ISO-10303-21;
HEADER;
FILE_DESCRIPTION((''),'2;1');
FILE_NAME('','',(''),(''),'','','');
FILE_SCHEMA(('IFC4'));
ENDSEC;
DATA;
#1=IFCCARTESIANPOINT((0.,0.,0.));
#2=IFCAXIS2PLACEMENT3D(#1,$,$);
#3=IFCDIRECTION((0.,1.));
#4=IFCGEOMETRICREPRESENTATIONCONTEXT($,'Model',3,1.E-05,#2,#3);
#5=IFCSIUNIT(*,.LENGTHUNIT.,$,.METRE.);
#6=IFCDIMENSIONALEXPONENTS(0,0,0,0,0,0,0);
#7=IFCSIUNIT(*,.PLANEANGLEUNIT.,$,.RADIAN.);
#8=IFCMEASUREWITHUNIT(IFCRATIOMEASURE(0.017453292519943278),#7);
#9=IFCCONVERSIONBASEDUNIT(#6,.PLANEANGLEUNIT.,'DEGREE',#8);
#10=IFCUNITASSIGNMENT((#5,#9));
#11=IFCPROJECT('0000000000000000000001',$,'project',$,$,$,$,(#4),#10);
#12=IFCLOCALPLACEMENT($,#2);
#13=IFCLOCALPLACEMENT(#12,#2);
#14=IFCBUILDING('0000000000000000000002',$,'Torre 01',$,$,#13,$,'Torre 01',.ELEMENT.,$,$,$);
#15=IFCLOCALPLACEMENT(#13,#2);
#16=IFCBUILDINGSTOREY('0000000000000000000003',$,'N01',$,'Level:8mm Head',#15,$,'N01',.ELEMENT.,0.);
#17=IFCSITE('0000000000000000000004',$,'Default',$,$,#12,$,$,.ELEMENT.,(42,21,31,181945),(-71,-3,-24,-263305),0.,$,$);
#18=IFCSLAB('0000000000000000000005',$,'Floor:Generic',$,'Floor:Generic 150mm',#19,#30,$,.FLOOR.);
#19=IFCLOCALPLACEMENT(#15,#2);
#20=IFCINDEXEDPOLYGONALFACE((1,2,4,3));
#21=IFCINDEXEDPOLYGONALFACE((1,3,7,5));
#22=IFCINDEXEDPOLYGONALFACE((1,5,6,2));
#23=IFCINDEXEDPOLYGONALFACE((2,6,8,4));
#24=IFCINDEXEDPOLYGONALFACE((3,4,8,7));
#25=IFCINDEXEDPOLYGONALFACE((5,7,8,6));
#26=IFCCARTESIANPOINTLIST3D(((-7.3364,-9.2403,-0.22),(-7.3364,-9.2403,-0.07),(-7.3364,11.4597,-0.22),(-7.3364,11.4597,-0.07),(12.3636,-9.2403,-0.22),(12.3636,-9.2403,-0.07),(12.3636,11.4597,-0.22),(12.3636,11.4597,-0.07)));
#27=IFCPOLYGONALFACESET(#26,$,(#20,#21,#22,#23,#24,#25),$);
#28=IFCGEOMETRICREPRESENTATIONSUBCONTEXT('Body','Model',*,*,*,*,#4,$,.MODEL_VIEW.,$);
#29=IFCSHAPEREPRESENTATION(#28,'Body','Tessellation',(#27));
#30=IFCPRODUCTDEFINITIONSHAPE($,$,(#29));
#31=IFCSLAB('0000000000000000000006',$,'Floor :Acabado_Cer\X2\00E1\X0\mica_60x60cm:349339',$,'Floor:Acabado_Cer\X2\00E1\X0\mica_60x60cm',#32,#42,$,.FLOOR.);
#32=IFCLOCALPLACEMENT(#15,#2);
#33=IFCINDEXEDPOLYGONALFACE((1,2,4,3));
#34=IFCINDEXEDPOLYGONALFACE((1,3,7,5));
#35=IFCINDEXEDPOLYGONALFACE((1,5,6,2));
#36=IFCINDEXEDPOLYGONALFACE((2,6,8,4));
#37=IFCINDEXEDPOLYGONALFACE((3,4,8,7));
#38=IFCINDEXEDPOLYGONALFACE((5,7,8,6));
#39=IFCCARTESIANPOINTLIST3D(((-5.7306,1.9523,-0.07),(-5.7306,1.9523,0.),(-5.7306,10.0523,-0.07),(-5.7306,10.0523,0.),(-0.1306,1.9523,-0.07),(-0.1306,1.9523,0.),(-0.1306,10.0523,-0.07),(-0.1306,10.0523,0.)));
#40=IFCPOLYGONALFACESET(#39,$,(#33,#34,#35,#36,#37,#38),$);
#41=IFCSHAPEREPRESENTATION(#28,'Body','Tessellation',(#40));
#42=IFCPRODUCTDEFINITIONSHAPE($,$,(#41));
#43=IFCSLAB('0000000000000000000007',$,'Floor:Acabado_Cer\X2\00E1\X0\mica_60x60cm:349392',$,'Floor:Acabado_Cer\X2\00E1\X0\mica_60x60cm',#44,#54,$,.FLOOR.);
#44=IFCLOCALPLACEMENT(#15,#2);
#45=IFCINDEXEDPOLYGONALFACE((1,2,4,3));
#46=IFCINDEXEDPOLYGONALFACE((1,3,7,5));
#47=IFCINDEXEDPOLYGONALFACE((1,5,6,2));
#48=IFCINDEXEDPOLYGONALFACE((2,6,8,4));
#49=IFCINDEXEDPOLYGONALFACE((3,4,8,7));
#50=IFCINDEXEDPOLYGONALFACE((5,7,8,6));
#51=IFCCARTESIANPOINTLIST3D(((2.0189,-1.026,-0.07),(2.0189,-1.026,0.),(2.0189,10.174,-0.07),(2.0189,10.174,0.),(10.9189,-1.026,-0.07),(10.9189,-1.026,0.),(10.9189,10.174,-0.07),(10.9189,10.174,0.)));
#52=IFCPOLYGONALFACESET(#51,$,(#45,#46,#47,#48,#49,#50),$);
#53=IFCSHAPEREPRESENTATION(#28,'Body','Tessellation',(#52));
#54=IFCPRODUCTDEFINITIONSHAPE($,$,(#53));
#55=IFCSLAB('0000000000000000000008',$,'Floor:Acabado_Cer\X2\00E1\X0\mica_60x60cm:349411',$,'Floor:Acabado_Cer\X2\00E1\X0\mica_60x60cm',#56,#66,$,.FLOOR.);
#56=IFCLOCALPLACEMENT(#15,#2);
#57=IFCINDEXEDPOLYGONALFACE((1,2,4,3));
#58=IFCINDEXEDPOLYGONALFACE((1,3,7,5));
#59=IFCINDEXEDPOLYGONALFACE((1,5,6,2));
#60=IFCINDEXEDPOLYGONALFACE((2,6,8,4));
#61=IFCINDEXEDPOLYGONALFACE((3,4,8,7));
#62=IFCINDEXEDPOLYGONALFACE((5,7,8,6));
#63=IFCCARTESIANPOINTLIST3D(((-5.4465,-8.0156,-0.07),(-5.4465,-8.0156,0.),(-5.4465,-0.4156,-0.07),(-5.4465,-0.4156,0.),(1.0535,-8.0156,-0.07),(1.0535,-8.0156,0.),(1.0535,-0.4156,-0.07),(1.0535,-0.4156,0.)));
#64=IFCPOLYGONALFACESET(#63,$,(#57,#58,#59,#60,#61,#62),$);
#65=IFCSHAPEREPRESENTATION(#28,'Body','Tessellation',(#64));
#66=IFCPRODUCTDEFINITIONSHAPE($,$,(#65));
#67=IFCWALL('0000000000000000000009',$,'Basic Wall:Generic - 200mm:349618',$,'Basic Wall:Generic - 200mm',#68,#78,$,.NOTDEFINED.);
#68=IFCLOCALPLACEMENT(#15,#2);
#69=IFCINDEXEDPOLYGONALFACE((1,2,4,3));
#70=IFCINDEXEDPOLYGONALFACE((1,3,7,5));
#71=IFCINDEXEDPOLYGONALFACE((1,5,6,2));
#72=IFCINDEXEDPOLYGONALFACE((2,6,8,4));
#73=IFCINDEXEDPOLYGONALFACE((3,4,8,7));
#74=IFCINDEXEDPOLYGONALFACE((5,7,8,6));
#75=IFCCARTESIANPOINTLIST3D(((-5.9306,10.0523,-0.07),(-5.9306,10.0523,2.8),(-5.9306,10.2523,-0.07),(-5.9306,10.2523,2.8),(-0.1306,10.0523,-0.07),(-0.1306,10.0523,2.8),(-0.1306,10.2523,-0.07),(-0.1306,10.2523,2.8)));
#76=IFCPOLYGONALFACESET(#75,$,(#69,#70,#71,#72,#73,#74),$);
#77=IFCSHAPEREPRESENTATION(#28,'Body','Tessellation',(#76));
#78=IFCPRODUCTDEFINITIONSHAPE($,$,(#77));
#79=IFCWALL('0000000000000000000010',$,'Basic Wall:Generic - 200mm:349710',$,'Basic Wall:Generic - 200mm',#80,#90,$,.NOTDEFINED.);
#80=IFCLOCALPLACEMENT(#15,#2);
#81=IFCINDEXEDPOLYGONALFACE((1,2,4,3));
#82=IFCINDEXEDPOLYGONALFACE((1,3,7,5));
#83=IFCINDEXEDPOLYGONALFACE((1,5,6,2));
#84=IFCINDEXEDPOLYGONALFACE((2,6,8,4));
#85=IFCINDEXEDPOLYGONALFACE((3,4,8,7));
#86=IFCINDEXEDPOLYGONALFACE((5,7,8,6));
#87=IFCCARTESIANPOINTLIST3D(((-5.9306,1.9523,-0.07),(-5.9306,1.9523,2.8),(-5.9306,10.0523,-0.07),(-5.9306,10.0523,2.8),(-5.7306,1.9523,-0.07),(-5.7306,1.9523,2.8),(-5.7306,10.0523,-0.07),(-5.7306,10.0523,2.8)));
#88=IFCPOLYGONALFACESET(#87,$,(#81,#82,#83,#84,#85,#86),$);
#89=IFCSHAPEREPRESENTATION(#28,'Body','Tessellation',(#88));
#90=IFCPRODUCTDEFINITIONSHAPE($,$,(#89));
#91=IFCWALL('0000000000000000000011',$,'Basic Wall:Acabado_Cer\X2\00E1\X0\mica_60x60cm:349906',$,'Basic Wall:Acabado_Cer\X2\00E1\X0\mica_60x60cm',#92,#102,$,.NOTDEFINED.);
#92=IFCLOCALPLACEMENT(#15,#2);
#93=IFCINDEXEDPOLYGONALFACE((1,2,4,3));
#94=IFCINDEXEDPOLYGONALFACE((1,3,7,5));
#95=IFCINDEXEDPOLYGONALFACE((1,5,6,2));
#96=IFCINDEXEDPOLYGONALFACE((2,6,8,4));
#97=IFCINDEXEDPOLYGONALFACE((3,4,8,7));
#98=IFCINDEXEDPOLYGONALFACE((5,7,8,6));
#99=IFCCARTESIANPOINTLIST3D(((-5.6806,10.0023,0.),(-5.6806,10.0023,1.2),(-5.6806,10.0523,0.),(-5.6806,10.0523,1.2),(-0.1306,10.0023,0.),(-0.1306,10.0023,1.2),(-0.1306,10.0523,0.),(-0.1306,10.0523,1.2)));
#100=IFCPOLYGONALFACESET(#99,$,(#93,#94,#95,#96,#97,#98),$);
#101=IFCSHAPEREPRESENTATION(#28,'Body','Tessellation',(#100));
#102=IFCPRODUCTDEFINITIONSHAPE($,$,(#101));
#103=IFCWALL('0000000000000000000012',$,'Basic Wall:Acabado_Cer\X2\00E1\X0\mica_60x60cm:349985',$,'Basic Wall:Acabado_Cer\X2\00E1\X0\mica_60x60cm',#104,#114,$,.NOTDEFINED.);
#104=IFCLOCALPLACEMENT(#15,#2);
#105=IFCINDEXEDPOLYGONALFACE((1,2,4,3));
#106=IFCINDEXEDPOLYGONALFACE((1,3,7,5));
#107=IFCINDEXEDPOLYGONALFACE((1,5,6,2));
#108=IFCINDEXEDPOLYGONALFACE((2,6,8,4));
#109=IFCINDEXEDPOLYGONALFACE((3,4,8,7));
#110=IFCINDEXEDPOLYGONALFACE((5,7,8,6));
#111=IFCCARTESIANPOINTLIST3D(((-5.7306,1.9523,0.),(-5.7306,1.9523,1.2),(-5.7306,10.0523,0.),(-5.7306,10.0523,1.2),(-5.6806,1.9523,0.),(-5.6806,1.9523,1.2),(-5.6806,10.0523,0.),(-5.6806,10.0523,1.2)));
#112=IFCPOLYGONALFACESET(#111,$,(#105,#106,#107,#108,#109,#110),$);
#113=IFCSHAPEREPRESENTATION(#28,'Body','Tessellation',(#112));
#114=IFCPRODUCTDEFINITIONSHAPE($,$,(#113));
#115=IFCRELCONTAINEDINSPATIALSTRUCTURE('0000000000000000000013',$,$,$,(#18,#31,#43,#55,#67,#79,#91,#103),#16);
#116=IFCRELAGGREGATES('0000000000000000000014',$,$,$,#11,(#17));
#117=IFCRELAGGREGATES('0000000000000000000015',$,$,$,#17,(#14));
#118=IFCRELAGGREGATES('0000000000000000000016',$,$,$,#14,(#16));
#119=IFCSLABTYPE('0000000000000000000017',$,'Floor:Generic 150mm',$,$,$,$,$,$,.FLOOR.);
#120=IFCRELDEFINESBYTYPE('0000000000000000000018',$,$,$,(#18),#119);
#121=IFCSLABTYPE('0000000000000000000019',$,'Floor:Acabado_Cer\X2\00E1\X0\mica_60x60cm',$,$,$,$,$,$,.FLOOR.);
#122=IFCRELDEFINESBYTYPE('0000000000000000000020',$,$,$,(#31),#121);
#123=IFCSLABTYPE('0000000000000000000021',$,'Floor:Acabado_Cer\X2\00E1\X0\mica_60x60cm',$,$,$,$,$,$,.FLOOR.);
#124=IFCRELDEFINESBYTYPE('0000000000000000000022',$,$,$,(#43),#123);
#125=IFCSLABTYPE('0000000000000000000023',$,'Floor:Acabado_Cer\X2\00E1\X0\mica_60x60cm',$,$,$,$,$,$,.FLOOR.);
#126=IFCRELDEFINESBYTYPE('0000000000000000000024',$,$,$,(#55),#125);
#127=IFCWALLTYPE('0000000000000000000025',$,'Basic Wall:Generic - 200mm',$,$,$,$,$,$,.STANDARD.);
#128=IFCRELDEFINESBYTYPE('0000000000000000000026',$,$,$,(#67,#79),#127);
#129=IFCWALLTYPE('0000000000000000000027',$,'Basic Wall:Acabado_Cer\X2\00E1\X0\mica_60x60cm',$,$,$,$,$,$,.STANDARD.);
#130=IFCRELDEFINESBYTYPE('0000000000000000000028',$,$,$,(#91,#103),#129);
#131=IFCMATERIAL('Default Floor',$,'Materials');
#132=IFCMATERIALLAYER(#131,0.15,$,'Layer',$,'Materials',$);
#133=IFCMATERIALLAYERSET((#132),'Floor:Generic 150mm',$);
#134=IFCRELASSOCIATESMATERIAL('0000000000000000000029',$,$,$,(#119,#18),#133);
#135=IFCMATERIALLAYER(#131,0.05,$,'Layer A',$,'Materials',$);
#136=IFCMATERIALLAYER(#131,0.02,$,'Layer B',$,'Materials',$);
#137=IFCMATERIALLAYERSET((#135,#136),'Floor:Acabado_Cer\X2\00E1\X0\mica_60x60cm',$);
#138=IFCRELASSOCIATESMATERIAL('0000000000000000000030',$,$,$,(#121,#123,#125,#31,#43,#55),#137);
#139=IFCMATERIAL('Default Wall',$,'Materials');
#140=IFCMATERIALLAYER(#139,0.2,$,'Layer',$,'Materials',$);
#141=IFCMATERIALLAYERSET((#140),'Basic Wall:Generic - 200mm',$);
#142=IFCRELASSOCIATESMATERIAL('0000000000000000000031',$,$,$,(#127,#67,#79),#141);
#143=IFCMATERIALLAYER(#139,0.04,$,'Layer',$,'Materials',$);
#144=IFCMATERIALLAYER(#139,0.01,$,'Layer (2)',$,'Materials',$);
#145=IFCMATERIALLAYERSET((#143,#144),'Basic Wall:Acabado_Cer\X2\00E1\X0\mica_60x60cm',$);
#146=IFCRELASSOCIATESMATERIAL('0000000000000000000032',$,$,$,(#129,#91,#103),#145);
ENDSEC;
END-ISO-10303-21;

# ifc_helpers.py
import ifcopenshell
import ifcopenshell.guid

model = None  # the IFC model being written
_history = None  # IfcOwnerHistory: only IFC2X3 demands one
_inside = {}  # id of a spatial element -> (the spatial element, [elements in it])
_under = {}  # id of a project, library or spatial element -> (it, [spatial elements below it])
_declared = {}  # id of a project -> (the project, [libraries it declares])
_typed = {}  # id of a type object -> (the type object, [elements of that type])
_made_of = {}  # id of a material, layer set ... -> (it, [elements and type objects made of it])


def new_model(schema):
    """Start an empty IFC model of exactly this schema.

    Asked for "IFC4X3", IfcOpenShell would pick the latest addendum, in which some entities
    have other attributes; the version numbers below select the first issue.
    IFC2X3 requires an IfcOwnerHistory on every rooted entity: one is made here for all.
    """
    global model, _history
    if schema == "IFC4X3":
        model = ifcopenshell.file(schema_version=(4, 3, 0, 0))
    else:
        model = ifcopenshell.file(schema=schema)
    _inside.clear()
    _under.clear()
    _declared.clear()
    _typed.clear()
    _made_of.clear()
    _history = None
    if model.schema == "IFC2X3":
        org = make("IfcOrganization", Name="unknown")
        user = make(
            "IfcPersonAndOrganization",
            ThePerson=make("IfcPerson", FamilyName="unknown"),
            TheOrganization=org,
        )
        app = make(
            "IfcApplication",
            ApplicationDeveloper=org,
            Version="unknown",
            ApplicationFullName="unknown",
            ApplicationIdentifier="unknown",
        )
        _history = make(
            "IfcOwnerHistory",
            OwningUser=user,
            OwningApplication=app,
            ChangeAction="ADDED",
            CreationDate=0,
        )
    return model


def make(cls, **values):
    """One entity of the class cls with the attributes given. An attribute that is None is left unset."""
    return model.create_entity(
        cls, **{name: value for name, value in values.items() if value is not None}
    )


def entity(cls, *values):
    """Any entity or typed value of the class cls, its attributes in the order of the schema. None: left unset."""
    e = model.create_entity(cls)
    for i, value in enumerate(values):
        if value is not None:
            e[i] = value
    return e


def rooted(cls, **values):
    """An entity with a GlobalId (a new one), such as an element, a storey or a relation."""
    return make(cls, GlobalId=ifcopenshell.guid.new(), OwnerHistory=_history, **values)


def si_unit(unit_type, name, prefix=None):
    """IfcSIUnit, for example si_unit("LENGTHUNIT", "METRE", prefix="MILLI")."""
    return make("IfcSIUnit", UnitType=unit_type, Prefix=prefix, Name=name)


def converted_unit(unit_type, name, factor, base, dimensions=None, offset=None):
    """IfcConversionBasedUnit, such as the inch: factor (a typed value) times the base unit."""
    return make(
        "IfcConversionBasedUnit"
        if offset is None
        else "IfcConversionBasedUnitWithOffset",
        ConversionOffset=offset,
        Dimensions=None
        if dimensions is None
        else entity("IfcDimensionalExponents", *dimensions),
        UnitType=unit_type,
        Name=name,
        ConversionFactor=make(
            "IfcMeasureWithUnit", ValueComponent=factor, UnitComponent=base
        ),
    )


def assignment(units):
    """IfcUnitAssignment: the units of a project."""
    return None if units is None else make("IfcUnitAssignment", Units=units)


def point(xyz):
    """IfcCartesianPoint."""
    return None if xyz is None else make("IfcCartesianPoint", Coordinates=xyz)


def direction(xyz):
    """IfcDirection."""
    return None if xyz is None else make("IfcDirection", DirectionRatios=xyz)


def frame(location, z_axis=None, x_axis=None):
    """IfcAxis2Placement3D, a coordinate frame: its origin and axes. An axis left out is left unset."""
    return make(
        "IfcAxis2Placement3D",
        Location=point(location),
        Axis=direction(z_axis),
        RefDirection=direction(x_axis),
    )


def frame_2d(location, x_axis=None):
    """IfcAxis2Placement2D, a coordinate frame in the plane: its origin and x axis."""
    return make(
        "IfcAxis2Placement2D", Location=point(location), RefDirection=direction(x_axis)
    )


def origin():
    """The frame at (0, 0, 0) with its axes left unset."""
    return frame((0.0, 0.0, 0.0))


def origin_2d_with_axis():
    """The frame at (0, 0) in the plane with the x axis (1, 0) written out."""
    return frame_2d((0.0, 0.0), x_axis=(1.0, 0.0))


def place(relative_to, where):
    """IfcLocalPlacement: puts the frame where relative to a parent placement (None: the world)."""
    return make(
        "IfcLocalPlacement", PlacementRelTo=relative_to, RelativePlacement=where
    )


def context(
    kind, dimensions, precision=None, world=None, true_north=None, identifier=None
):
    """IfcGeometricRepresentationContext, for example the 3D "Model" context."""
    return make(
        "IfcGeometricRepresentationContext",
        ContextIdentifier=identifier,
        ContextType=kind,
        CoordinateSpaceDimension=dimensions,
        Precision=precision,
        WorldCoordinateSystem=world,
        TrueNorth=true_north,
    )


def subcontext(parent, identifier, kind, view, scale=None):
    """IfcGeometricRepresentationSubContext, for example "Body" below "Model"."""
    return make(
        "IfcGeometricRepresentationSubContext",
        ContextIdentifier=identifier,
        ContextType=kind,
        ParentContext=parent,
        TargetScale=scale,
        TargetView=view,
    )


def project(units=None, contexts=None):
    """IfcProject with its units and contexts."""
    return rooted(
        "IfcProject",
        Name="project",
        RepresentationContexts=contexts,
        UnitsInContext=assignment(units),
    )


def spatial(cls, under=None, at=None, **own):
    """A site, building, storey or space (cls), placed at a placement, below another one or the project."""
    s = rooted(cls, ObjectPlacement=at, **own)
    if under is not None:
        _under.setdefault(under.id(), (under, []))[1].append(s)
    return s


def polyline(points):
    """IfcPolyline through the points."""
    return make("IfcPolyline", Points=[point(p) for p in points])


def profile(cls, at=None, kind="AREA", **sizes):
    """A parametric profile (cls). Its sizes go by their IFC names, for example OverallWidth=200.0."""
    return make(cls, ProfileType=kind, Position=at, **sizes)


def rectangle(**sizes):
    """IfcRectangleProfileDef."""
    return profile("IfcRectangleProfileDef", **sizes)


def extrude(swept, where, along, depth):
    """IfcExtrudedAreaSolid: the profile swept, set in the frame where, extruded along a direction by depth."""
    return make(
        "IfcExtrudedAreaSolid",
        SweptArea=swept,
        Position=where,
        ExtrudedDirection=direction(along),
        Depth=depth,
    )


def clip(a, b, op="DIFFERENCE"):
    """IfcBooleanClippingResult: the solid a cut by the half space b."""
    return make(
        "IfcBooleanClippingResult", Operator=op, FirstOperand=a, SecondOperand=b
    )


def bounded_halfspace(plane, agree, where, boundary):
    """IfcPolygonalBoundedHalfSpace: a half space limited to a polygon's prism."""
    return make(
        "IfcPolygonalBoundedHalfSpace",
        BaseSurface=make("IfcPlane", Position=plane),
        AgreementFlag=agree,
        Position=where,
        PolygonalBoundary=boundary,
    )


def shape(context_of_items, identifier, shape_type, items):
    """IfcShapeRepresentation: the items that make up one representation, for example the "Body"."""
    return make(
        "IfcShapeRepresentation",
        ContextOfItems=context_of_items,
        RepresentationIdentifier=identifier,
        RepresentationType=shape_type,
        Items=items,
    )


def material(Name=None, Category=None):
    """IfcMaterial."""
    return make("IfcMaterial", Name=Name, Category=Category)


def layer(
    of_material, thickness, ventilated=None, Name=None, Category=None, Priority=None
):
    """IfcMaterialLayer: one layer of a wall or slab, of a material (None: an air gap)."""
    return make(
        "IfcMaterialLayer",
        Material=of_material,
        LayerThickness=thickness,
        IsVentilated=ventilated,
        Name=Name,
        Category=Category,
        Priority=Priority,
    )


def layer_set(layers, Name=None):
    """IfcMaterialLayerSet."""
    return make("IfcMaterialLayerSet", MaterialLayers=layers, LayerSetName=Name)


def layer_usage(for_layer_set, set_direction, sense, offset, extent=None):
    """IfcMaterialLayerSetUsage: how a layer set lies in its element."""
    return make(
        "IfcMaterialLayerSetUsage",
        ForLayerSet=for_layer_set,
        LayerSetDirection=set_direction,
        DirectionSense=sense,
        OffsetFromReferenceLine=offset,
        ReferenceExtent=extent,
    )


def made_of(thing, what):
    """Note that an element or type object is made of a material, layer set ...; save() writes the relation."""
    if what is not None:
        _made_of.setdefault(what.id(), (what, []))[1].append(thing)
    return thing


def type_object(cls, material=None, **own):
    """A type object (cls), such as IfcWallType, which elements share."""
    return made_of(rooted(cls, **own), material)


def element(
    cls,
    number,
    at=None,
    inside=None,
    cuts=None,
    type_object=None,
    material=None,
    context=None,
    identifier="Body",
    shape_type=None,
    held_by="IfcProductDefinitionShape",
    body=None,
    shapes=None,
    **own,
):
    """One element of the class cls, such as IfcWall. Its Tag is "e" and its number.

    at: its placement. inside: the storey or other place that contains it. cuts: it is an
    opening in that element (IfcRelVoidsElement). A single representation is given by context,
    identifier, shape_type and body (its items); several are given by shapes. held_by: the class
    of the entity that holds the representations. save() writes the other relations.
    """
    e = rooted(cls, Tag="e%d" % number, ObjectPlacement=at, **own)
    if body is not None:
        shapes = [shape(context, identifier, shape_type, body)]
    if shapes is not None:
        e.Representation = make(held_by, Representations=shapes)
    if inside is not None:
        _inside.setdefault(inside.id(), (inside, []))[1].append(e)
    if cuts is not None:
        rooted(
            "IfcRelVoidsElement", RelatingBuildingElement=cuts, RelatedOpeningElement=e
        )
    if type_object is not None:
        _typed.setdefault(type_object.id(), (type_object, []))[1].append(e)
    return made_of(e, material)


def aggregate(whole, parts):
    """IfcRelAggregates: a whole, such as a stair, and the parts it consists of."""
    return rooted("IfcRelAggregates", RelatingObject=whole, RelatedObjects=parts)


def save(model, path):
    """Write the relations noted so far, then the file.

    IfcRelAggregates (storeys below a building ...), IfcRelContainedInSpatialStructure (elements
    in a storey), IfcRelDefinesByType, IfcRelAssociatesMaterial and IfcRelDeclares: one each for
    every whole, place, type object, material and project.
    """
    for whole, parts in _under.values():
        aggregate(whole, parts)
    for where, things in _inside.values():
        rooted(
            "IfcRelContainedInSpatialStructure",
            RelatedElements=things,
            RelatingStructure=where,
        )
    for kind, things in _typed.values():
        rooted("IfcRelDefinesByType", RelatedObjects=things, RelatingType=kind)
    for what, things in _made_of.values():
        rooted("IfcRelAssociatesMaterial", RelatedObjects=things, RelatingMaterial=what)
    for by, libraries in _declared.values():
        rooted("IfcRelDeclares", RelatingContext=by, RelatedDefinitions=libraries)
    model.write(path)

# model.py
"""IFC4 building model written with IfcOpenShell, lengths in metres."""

from ifc_helpers import new_model, entity, si_unit, converted_unit, direction, frame, frame_2d, origin, origin_2d_with_axis, place, context, subcontext, project, spatial, polyline, rectangle, extrude, clip, bounded_halfspace, material, layer, layer_set, layer_usage, type_object, element, save


model = new_model("IFC4")

# Units and contexts
model_context = context("Model", 3, precision=1e-05, world=origin(), true_north=direction((0.0, 1.0)))
body_context = subcontext(model_context, "Body", "Model", "MODEL_VIEW")
ifc_project = project(units=[si_unit("LENGTHUNIT", "METRE"), converted_unit("PLANEANGLEUNIT", "DEGREE", entity("IfcRatioMeasure", 0.017453292519943278), si_unit("PLANEANGLEUNIT", "RADIAN"), dimensions=[0, 0, 0, 0, 0, 0, 0])], contexts=[model_context])

# Site, building, storey
site_placement = place(None, origin())
site = spatial("IfcSite", under=ifc_project, at=site_placement, Name="Default", CompositionType="ELEMENT", RefLatitude=(42, 21, 31, 181945), RefLongitude=(-71, -3, -24, -263305), RefElevation=0.0)
building_placement = place(site_placement, origin())
building = spatial("IfcBuilding", under=site, at=building_placement, Name="Torre 01", LongName="Torre 01", CompositionType="ELEMENT")
storey_placement = place(building_placement, origin())
storey = spatial("IfcBuildingStorey", under=building, at=storey_placement, Name="N01", ObjectType="Level:8mm Head", LongName="N01", CompositionType="ELEMENT", Elevation=0.0)

# Slabs
ifc_material_1 = material(Name="Default Floor", Category="Materials")
ifc_layer_1 = layer(ifc_material_1, 0.15, Name="Layer", Category="Materials")
ifc_layer_set_1 = layer_set([ifc_layer_1], Name="Floor:Generic 150mm")
ifc_layer_usage_1 = layer_usage(ifc_layer_set_1, "AXIS3", "POSITIVE", 0.0)
slab_type_1 = type_object("IfcSlabType", Name="Floor:Generic 150mm", PredefinedType="FLOOR", material=ifc_layer_set_1)
slab_1_placement = place(storey_placement, origin())
element("IfcSlab", 1, at=slab_1_placement, inside=storey, type_object=slab_type_1, material=ifc_layer_usage_1, Name="Floor:Generic", ObjectType="Floor:Generic 150mm", PredefinedType="FLOOR", context=body_context, shape_type="SweptSolid", body=[
    extrude(rectangle(XDim=20.7, YDim=19.7, at=origin_2d_with_axis()), frame((2.5136, 1.1097, -0.07), z_axis=(0.0, 0.0, -1.0), x_axis=(0.0, 1.0, 0.0)), (0.0, 0.0, 1.0), 0.15),
])
ifc_layer_2 = layer(ifc_material_1, 0.05, Name="Layer A", Category="Materials")
ifc_layer_3 = layer(ifc_material_1, 0.02, Name="Layer B", Category="Materials")
ifc_layer_set_2 = layer_set([ifc_layer_2, ifc_layer_3], Name="Floor:Acabado_Cerámica_60x60cm")
ifc_layer_usage_2 = layer_usage(ifc_layer_set_2, "AXIS3", "POSITIVE", 0.0)
slab_type_2 = type_object("IfcSlabType", Name="Floor:Acabado_Cerámica_60x60cm", PredefinedType="FLOOR", material=ifc_layer_set_2)
slab_2_placement = place(storey_placement, origin())
element("IfcSlab", 2, at=slab_2_placement, inside=storey, type_object=slab_type_2, material=ifc_layer_usage_2, Name="Floor :Acabado_Cerámica_60x60cm:349339", ObjectType="Floor:Acabado_Cerámica_60x60cm", PredefinedType="FLOOR", context=body_context, shape_type="SweptSolid", body=[
    extrude(rectangle(XDim=8.1, YDim=5.6, at=frame_2d((0.0, 0.0), x_axis=(1.0, 0.0))), frame((-2.9306, 6.0023, 0.0), z_axis=(0.0, 0.0, -1.0), x_axis=(0.0, 1.0, 0.0)), (0.0, 0.0, 1.0), 0.07),
])
ifc_layer_usage_3 = layer_usage(ifc_layer_set_2, "AXIS3", "POSITIVE", 0.0)
slab_type_3 = type_object("IfcSlabType", Name="Floor:Acabado_Cerámica_60x60cm", PredefinedType="FLOOR", material=ifc_layer_set_2)
slab_3_placement = place(storey_placement, origin())
element("IfcSlab", 3, at=slab_3_placement, inside=storey, type_object=slab_type_3, material=ifc_layer_usage_3, Name="Floor:Acabado_Cerámica_60x60cm:349392", ObjectType="Floor:Acabado_Cerámica_60x60cm", PredefinedType="FLOOR", context=body_context, shape_type="SweptSolid", body=[
    extrude(rectangle(XDim=11.2, YDim=8.9, at=origin_2d_with_axis()), frame((6.4689, 4.574, 0.0), z_axis=(0.0, 0.0, -1.0), x_axis=(0.0, 1.0, 0.0)), (0.0, 0.0, 1.0), 0.07),
])
ifc_layer_usage_4 = layer_usage(ifc_layer_set_2, "AXIS3", "POSITIVE", 0.0)
slab_type_4 = type_object("IfcSlabType", Name="Floor:Acabado_Cerámica_60x60cm", PredefinedType="FLOOR", material=ifc_layer_set_2)
slab_4_placement = place(storey_placement, origin())
element("IfcSlab", 4, at=slab_4_placement, inside=storey, type_object=slab_type_4, material=ifc_layer_usage_4, Name="Floor:Acabado_Cerámica_60x60cm:349411", ObjectType="Floor:Acabado_Cerámica_60x60cm", PredefinedType="FLOOR", context=body_context, shape_type="SweptSolid", body=[
    extrude(rectangle(XDim=7.6, YDim=6.5, at=frame_2d((0.0, 0.0), x_axis=(1.0, 0.0))), frame((-2.1965, -4.2156, 0.0), z_axis=(0.0, 0.0, -1.0), x_axis=(0.0, 1.0, 0.0)), (0.0, 0.0, 1.0), 0.07),
])

# Walls
ifc_material_2 = material(Name="Default Wall", Category="Materials")
ifc_layer_4 = layer(ifc_material_2, 0.2, Name="Layer", Category="Materials")
ifc_layer_set_3 = layer_set([ifc_layer_4], Name="Basic Wall:Generic - 200mm")
ifc_layer_usage_5 = layer_usage(ifc_layer_set_3, "AXIS2", "POSITIVE", -0.1)
wall_type_1 = type_object("IfcWallType", Name="Basic Wall:Generic - 200mm", PredefinedType="STANDARD", material=ifc_layer_set_3)
wall_1_placement = place(storey_placement, frame((-0.1306, 10.1523, -0.07), z_axis=(0.0, 0.0, 1.0), x_axis=(-1.0, 0.0, 0.0)))
element("IfcWall", 5, at=wall_1_placement, inside=storey, type_object=wall_type_1, material=ifc_layer_usage_5, Name="Basic Wall:Generic - 200mm:349618", ObjectType="Basic Wall:Generic - 200mm", PredefinedType="NOTDEFINED", context=body_context, shape_type="SweptSolid", body=[
    extrude(rectangle(XDim=5.8, YDim=0.2, at=frame_2d((2.9, 0.0), x_axis=(-1.0, 0.0))), origin(), (0.0, 0.0, 1.0), 2.87),
])
ifc_layer_usage_6 = layer_usage(ifc_layer_set_3, "AXIS2", "POSITIVE", -0.1)
wall_2_placement = place(storey_placement, frame((-5.8306, 10.0523, -0.07), z_axis=(0.0, 0.0, 1.0), x_axis=(0.0, -1.0, 0.0)))
element("IfcWall", 6, at=wall_2_placement, inside=storey, type_object=wall_type_1, material=ifc_layer_usage_6, Name="Basic Wall:Generic - 200mm:349710", ObjectType="Basic Wall:Generic - 200mm", PredefinedType="NOTDEFINED", context=body_context, shape_type="SweptSolid", body=[
    extrude(rectangle(XDim=8.1, YDim=0.2, at=frame_2d((4.05, 0.0), x_axis=(-1.0, 0.0))), origin(), (0.0, 0.0, 1.0), 2.87),
])
ifc_layer_5 = layer(ifc_material_2, 0.04, Name="Layer", Category="Materials")
ifc_layer_6 = layer(ifc_material_2, 0.01, Name="Layer (2)", Category="Materials")
ifc_layer_set_4 = layer_set([ifc_layer_5, ifc_layer_6], Name="Basic Wall:Acabado_Cerámica_60x60cm")
ifc_layer_usage_7 = layer_usage(ifc_layer_set_4, "AXIS2", "NEGATIVE", 0.025)
wall_type_2 = type_object("IfcWallType", Name="Basic Wall:Acabado_Cerámica_60x60cm", PredefinedType="STANDARD", material=ifc_layer_set_4)
wall_3_placement = place(storey_placement, frame((-0.1306, 10.0273, 0.0), z_axis=(0.0, 0.0, 1.0), x_axis=(-1.0, 0.0, 0.0)))
element("IfcWall", 7, at=wall_3_placement, inside=storey, type_object=wall_type_2, material=ifc_layer_usage_7, Name="Basic Wall:Acabado_Cerámica_60x60cm:349906", ObjectType="Basic Wall:Acabado_Cerámica_60x60cm", PredefinedType="NOTDEFINED", context=body_context, shape_type="Clipping", body=[
    clip(extrude(rectangle(XDim=5.55, YDim=0.05, at=frame_2d((2.775, 0.0), x_axis=(-1.0, 0.0))), origin(), (0.0, 0.0, 1.0), 1.2), bounded_halfspace(frame((5.55, -0.025, 1.2), z_axis=(-1.0, 0.0, 0.0), x_axis=(0.0, -1.0, 0.0)), True, frame((5.55, -0.025, 1.2), z_axis=(-1.0, 0.0, 0.0), x_axis=(0.0, -1.0, 0.0)), polyline([(0.0, 0.0), (-0.05, 0.0), (-0.05, -1.2), (0.0, -1.2), (0.0, 0.0)]))),
])
ifc_layer_usage_8 = layer_usage(ifc_layer_set_4, "AXIS2", "NEGATIVE", 0.025)
wall_4_placement = place(storey_placement, frame((-5.7056, 10.0523, 0.0), z_axis=(0.0, 0.0, 1.0), x_axis=(0.0, -1.0, 0.0)))
element("IfcWall", 8, at=wall_4_placement, inside=storey, type_object=wall_type_2, material=ifc_layer_usage_8, Name="Basic Wall:Acabado_Cerámica_60x60cm:349985", ObjectType="Basic Wall:Acabado_Cerámica_60x60cm", PredefinedType="NOTDEFINED", context=body_context, shape_type="SweptSolid", body=[
    extrude(rectangle(XDim=8.1, YDim=0.05, at=frame_2d((4.05, 0.0), x_axis=(-1.0, 0.0))), origin(), (0.0, 0.0, 1.0), 1.2),
])

save(model, "model.ifc")
